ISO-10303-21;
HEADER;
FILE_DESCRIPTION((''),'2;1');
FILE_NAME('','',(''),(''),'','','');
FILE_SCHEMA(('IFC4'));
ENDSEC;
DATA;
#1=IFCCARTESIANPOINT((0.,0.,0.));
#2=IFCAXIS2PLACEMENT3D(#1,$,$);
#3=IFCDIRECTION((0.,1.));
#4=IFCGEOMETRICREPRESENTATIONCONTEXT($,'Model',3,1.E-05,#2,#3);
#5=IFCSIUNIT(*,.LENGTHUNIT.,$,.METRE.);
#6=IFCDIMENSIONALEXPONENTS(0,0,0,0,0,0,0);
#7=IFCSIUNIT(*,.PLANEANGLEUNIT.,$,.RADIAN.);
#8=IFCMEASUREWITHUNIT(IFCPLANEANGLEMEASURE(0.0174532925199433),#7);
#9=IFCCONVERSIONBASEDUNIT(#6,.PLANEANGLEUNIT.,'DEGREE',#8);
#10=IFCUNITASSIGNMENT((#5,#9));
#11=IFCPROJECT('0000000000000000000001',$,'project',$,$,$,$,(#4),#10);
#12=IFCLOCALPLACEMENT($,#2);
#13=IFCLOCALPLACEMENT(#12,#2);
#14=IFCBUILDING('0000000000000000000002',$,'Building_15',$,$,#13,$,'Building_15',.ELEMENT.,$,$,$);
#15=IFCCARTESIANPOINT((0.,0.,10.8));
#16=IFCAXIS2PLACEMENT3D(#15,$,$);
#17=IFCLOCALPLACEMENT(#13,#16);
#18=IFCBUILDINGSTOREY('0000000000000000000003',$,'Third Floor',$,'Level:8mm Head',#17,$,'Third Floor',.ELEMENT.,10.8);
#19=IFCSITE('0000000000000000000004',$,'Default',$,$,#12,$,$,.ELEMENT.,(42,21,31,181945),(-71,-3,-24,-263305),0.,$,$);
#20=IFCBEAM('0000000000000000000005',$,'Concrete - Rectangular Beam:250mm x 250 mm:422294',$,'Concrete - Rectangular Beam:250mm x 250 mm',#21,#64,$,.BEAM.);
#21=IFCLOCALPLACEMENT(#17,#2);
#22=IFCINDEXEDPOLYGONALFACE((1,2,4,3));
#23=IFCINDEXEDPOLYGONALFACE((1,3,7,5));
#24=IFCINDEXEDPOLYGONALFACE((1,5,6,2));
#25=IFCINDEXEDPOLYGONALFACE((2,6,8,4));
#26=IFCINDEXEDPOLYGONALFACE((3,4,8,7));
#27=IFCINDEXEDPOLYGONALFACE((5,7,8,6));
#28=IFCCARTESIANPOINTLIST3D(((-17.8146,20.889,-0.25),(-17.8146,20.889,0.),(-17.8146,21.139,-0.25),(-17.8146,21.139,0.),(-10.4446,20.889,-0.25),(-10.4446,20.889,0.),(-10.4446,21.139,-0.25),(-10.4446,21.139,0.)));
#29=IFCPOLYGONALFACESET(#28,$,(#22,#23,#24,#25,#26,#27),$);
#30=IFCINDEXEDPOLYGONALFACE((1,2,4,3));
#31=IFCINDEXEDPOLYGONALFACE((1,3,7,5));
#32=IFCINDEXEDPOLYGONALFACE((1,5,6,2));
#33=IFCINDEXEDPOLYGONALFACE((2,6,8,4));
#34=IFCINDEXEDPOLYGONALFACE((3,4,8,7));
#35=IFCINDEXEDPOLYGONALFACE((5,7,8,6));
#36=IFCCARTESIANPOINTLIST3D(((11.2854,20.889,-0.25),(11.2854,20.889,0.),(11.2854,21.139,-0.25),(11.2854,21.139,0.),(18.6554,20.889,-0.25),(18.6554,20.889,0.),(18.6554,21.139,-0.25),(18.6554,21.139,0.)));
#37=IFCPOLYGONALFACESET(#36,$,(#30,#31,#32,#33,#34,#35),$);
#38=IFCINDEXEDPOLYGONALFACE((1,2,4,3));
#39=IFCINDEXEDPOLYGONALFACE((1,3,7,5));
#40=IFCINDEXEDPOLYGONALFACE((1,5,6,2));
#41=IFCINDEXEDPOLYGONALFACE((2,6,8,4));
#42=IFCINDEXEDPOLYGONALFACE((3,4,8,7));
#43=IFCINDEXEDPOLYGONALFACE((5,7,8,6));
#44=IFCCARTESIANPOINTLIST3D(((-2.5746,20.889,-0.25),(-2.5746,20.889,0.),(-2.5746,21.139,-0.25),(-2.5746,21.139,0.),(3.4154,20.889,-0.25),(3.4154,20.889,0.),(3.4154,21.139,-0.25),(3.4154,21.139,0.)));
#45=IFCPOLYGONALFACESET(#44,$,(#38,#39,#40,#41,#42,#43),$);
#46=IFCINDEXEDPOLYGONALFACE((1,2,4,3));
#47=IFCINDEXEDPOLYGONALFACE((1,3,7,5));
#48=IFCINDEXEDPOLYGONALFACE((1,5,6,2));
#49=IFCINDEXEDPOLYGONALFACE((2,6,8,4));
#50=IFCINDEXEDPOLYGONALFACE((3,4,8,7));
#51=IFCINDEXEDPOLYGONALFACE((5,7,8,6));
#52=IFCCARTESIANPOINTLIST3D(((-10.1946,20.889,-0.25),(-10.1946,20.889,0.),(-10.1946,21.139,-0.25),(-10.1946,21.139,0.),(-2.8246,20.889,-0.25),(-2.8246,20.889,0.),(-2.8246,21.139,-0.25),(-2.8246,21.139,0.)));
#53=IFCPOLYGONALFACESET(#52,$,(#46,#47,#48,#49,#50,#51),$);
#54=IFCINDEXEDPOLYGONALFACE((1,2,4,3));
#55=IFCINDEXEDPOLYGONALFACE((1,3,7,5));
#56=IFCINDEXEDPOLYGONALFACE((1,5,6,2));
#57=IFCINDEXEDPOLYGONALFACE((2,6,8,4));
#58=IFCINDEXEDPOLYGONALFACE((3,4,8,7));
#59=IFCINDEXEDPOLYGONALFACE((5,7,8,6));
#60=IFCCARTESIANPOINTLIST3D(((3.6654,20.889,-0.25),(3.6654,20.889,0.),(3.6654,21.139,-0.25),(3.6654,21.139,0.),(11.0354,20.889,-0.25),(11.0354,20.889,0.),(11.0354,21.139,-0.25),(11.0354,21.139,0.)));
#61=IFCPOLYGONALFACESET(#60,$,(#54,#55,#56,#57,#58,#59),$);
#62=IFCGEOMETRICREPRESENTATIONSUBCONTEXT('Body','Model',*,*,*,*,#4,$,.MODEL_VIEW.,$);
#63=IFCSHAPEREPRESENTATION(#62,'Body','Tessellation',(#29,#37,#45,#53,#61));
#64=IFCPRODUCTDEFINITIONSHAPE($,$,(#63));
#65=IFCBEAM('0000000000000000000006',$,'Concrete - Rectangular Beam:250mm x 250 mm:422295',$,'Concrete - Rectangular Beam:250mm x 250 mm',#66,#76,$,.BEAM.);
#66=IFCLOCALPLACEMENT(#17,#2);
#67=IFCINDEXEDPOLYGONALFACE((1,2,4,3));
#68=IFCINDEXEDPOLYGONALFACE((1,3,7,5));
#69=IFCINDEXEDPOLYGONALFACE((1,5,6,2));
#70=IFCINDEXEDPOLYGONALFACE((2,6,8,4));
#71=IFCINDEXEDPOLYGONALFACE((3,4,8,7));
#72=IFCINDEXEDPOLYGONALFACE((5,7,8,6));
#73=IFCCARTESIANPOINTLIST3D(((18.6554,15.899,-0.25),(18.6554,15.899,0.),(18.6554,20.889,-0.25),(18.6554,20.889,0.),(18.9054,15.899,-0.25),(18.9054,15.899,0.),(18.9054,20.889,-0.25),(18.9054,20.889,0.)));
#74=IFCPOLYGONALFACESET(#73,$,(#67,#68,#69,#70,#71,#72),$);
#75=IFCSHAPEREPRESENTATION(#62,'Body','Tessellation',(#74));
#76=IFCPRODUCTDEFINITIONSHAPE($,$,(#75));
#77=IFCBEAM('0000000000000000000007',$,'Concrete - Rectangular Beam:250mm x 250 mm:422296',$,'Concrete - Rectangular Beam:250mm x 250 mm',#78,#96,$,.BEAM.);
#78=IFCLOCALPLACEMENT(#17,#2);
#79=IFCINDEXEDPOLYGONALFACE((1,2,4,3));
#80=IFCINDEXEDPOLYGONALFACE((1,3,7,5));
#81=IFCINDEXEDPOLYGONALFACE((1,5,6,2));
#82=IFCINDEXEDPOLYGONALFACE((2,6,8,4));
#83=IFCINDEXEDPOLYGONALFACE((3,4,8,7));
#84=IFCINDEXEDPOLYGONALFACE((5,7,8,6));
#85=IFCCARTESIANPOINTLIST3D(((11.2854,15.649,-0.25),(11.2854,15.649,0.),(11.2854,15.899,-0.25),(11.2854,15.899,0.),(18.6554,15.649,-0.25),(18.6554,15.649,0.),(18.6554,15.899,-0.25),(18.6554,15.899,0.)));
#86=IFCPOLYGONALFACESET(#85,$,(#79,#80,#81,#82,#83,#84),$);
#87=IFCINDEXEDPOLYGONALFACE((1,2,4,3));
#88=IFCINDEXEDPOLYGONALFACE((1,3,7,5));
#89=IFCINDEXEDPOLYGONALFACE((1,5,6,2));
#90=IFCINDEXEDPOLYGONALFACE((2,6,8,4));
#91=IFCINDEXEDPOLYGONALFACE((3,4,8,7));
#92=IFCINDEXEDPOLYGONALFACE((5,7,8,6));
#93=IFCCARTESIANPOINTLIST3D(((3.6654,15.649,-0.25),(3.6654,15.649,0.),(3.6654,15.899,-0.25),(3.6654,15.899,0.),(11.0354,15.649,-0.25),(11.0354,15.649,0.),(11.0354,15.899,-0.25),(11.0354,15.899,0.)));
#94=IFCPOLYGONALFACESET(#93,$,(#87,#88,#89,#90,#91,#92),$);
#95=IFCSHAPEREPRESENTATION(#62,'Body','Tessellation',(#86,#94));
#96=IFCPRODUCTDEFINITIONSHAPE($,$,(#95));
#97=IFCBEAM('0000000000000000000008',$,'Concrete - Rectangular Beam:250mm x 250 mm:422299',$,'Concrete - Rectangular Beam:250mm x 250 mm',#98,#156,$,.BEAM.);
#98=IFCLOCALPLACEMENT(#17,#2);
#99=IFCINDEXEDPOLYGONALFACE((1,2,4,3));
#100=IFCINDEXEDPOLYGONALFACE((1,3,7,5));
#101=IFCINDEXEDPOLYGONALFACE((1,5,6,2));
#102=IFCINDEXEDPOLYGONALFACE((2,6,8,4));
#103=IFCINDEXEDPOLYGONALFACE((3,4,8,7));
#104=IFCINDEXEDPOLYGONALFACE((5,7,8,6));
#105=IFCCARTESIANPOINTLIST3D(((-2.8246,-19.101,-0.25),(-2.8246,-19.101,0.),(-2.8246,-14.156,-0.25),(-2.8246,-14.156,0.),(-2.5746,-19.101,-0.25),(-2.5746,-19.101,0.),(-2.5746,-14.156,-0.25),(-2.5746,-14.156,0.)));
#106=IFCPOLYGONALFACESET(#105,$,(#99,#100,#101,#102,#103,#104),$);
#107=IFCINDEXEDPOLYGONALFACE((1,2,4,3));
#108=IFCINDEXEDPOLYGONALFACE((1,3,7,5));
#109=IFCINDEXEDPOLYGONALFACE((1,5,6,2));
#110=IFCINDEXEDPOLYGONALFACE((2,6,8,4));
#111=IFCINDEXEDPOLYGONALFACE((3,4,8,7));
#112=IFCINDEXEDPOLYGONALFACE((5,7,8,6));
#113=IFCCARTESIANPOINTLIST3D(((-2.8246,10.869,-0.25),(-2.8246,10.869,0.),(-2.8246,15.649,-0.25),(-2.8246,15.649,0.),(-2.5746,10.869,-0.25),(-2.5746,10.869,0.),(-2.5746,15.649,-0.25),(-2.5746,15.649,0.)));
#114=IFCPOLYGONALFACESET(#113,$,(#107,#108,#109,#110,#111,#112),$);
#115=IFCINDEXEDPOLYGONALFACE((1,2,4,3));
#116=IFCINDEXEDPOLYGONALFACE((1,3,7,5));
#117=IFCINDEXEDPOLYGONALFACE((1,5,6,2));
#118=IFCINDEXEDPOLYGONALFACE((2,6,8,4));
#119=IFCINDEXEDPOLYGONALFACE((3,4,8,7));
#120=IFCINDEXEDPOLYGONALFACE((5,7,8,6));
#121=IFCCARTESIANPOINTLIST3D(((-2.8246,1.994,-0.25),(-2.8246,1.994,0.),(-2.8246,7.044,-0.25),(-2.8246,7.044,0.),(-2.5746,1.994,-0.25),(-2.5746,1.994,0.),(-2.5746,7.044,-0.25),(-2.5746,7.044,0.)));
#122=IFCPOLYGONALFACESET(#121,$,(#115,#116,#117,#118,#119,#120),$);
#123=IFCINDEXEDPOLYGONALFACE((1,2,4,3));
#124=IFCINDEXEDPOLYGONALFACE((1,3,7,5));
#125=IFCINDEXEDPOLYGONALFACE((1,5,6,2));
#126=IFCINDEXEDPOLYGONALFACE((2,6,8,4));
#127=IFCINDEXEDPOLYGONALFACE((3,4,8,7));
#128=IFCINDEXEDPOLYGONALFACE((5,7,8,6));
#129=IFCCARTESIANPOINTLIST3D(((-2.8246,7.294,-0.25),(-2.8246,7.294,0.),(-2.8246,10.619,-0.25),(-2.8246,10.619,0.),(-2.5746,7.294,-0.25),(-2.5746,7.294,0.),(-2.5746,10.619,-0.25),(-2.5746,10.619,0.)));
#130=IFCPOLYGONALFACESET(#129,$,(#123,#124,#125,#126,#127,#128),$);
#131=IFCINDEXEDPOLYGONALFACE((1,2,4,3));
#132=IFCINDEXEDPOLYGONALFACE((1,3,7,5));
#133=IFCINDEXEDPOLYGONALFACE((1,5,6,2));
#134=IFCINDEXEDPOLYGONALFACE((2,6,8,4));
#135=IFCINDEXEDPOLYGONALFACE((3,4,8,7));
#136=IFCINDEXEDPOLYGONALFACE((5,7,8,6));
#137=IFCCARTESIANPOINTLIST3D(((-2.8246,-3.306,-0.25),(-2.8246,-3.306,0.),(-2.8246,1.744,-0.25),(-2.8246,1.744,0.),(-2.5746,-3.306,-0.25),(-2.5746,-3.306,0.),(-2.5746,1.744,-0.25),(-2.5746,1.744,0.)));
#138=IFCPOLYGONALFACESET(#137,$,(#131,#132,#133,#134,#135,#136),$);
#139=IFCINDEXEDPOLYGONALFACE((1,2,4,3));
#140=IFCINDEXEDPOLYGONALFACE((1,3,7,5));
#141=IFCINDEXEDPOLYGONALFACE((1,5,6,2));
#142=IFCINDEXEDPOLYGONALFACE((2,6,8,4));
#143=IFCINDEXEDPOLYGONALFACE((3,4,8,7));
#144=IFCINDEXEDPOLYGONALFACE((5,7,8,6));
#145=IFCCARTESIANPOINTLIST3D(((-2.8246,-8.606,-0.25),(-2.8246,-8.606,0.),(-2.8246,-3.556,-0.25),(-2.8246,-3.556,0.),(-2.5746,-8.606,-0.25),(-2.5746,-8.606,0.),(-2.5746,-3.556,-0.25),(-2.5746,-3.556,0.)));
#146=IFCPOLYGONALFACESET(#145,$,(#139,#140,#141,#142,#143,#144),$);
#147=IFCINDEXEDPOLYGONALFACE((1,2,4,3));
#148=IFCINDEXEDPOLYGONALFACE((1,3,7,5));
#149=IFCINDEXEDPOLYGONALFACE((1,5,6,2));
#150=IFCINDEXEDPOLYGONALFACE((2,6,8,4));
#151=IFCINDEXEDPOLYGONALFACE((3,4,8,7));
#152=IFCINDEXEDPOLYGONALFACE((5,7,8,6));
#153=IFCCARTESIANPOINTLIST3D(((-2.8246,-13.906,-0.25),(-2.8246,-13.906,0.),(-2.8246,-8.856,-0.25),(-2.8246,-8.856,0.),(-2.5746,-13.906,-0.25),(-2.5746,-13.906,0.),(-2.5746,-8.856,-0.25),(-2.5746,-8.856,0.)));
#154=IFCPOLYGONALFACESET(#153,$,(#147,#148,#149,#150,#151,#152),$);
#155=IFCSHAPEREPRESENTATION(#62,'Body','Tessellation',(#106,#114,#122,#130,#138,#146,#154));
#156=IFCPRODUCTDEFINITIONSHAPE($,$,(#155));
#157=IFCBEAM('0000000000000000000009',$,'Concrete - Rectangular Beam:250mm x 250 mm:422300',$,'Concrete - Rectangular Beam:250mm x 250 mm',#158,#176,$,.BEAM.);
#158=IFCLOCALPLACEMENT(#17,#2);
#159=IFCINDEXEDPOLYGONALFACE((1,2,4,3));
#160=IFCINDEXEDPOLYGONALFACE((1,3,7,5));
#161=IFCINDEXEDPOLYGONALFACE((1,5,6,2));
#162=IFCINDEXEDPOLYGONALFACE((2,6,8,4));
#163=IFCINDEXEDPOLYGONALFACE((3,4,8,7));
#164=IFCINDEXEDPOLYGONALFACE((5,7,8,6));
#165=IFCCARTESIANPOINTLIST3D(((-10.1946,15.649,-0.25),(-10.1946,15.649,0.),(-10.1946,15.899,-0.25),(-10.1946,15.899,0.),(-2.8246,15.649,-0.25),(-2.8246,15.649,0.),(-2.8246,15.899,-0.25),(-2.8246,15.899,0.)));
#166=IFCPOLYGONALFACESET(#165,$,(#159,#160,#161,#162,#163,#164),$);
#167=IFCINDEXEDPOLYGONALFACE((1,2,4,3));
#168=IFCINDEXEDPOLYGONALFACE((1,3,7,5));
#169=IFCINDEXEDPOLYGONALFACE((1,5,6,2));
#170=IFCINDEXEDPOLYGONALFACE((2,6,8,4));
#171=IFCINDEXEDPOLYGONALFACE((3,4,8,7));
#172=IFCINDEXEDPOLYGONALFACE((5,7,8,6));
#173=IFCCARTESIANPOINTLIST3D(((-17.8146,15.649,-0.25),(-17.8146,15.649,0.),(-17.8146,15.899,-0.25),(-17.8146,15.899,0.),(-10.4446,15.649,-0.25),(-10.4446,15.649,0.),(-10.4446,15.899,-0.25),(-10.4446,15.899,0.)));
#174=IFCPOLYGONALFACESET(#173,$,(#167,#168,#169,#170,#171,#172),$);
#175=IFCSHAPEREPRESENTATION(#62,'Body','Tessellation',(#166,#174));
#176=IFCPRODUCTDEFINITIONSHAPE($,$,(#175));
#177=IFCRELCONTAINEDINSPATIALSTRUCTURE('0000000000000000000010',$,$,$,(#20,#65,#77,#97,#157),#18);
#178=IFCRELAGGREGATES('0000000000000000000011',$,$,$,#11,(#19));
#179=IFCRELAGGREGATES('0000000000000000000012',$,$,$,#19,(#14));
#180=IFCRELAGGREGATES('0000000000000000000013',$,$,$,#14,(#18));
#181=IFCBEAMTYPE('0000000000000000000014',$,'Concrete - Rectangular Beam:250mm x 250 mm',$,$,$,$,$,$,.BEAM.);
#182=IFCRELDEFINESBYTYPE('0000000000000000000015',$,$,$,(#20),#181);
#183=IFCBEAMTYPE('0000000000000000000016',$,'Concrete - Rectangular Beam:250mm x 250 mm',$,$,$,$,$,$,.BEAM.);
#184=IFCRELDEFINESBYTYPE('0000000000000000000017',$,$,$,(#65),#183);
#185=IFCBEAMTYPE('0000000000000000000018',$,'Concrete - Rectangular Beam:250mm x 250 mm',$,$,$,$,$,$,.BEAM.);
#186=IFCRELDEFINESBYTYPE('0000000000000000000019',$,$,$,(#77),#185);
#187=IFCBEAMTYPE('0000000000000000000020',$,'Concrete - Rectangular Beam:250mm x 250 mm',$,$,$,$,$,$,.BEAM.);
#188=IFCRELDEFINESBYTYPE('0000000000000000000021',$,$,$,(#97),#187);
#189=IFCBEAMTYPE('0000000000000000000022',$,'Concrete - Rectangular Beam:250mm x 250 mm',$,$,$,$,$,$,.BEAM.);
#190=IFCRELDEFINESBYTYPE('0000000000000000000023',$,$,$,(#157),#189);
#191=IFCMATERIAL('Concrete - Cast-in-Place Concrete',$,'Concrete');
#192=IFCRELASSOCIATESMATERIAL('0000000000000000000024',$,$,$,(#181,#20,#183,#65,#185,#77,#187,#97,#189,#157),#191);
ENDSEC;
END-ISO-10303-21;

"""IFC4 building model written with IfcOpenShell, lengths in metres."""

from ifc_helpers import new_model, entity, si_unit, converted_unit, direction, frame, origin, place, context, subcontext, project, spatial, indexed_curve, outline, extrude, source, transform, mapped, material, type_object, type_shapes, element, save


model = new_model("IFC4")

# Units and contexts
model_context = context("Model", 3, precision=1e-05, world=origin(), true_north=direction((0.0, 1.0)))
body_context = subcontext(model_context, "Body", "Model", "MODEL_VIEW")
ifc_project = project(units=[si_unit("LENGTHUNIT", "METRE"), converted_unit("PLANEANGLEUNIT", "DEGREE", entity("IfcPlaneAngleMeasure", 0.0174532925199433), si_unit("PLANEANGLEUNIT", "RADIAN"), dimensions=[0, 0, 0, 0, 0, 0, 0])], contexts=[model_context])

# Site, building, storey
site_placement = place(None, origin())
site = spatial("IfcSite", under=ifc_project, at=site_placement, Name="Default", CompositionType="ELEMENT", RefLatitude=(42, 21, 31, 181945), RefLongitude=(-71, -3, -24, -263305), RefElevation=0.0)
building_placement = place(site_placement, origin())
building = spatial("IfcBuilding", under=site, at=building_placement, Name="Building_15", LongName="Building_15", CompositionType="ELEMENT")
storey_placement = place(building_placement, frame((0.0, 0.0, 10.8)))
storey = spatial("IfcBuildingStorey", under=building, at=storey_placement, Name="Third Floor", ObjectType="Level:8mm Head", LongName="Third Floor", CompositionType="ELEMENT", Elevation=10.8)

# Shared definitions
ifc_material_1 = material(Name="Concrete - Cast-in-Place Concrete", Category="Concrete")

# Beams
beam_type_1 = type_object("IfcBeamType", Name="Concrete - Rectangular Beam:250mm x 250 mm", PredefinedType="BEAM", material=ifc_material_1)
shared_shape_1 = source(origin(), body_context, "Body", "SweptSolid", [
    extrude(outline(indexed_curve([(-0.125, -0.125), (0.125, -0.125), (0.125, 0.125), (-0.125, 0.125), (-0.125, -0.125)], self_intersect=False)), frame((-17.8146, 21.014, 10.675), z_axis=(1.0, 0.0, 0.0), x_axis=(0.0, 0.0, -1.0)), (0.0, 0.0, 1.0), 7.37),
    extrude(outline(indexed_curve([(-0.125, -0.125), (0.125, -0.125), (0.125, 0.125), (-0.125, 0.125), (-0.125, -0.125)], self_intersect=False)), frame((11.2854, 21.014, 10.675), z_axis=(1.0, 0.0, 0.0), x_axis=(0.0, 0.0, -1.0)), (0.0, 0.0, 1.0), 7.37),
    extrude(outline(indexed_curve([(-0.125, -0.125), (0.125, -0.125), (0.125, 0.125), (-0.125, 0.125), (-0.125, -0.125)], self_intersect=False)), frame((-2.5746, 21.014, 10.675), z_axis=(1.0, 0.0, 0.0), x_axis=(0.0, 0.0, -1.0)), (0.0, 0.0, 1.0), 5.99),
    extrude(outline(indexed_curve([(-0.125, -0.125), (0.125, -0.125), (0.125, 0.125), (-0.125, 0.125), (-0.125, -0.125)], self_intersect=False)), frame((-10.1946, 21.014, 10.675), z_axis=(1.0, 0.0, 0.0), x_axis=(0.0, 0.0, -1.0)), (0.0, 0.0, 1.0), 7.37),
    extrude(outline(indexed_curve([(-0.125, -0.125), (0.125, -0.125), (0.125, 0.125), (-0.125, 0.125), (-0.125, -0.125)], self_intersect=False)), frame((3.6654, 21.014, 10.675), z_axis=(1.0, 0.0, 0.0), x_axis=(0.0, 0.0, -1.0)), (0.0, 0.0, 1.0), 7.37),
])
type_shapes(beam_type_1, [shared_shape_1])
beam_1_placement = place(storey_placement, frame((0.0, 0.0, -10.8)))
element("IfcBeam", 1, at=beam_1_placement, inside=storey, type_object=beam_type_1, material=ifc_material_1, Name="Concrete - Rectangular Beam:250mm x 250 mm:422294", ObjectType="Concrete - Rectangular Beam:250mm x 250 mm", PredefinedType="BEAM", context=body_context, shape_type="MappedRepresentation", body=[
    mapped(shared_shape_1, transform((0.0, 0.0, 0.0), scale=1.0)),
])
beam_type_2 = type_object("IfcBeamType", Name="Concrete - Rectangular Beam:250mm x 250 mm", PredefinedType="BEAM", material=ifc_material_1)
shared_shape_2 = source(origin(), body_context, "Body", "SweptSolid", [
    extrude(outline(indexed_curve([(-0.125, -0.125), (0.125, -0.125), (0.125, 0.125), (-0.125, 0.125), (-0.125, -0.125)], self_intersect=False)), frame((18.7804, 20.889, 10.675), z_axis=(0.0, -1.0, 0.0), x_axis=(-1.0, 0.0, 0.0)), (0.0, 0.0, 1.0), 4.99),
])
type_shapes(beam_type_2, [shared_shape_2])
beam_2_placement = place(storey_placement, frame((0.0, 0.0, -10.8)))
element("IfcBeam", 2, at=beam_2_placement, inside=storey, type_object=beam_type_2, material=ifc_material_1, Name="Concrete - Rectangular Beam:250mm x 250 mm:422295", ObjectType="Concrete - Rectangular Beam:250mm x 250 mm", PredefinedType="BEAM", context=body_context, shape_type="MappedRepresentation", body=[
    mapped(shared_shape_2, transform((0.0, 0.0, 0.0), scale=1.0)),
])
beam_type_3 = type_object("IfcBeamType", Name="Concrete - Rectangular Beam:250mm x 250 mm", PredefinedType="BEAM", material=ifc_material_1)
shared_shape_3 = source(origin(), body_context, "Body", "SweptSolid", [
    extrude(outline(indexed_curve([(-0.125, -0.125), (0.125, -0.125), (0.125, 0.125), (-0.125, 0.125), (-0.125, -0.125)], self_intersect=False)), frame((18.6554, 15.774, 10.675), z_axis=(-1.0, 0.0, 0.0), x_axis=(0.0, 0.0, -1.0)), (0.0, 0.0, 1.0), 7.37),
    extrude(outline(indexed_curve([(-0.125, -0.125), (0.125, -0.125), (0.125, 0.125), (-0.125, 0.125), (-0.125, -0.125)], self_intersect=False)), frame((11.0354, 15.774, 10.675), z_axis=(-1.0, 0.0, 0.0), x_axis=(0.0, 0.0, -1.0)), (0.0, 0.0, 1.0), 7.37),
])
type_shapes(beam_type_3, [shared_shape_3])
beam_3_placement = place(storey_placement, frame((0.0, 0.0, -10.8)))
element("IfcBeam", 3, at=beam_3_placement, inside=storey, type_object=beam_type_3, material=ifc_material_1, Name="Concrete - Rectangular Beam:250mm x 250 mm:422296", ObjectType="Concrete - Rectangular Beam:250mm x 250 mm", PredefinedType="BEAM", context=body_context, shape_type="MappedRepresentation", body=[
    mapped(shared_shape_3, transform((0.0, 0.0, 0.0), scale=1.0)),
])
beam_type_4 = type_object("IfcBeamType", Name="Concrete - Rectangular Beam:250mm x 250 mm", PredefinedType="BEAM", material=ifc_material_1)
shared_shape_4 = source(origin(), body_context, "Body", "SweptSolid", [
    extrude(outline(indexed_curve([(-0.125, -0.125), (0.125, -0.125), (0.125, 0.125), (-0.125, 0.125), (-0.125, -0.125)], self_intersect=False)), frame((-2.6996, -19.101, 10.675), z_axis=(0.0, 1.0, 0.0), x_axis=(-1.0, 0.0, 0.0)), (0.0, 0.0, 1.0), 4.945),
    extrude(outline(indexed_curve([(-0.125, -0.125), (0.125, -0.125), (0.125, 0.125), (-0.125, 0.125), (-0.125, -0.125)], self_intersect=False)), frame((-2.6996, 10.869, 10.675), z_axis=(0.0, 1.0, 0.0), x_axis=(-1.0, 0.0, 0.0)), (0.0, 0.0, 1.0), 4.78),
    extrude(outline(indexed_curve([(-0.125, -0.125), (0.125, -0.125), (0.125, 0.125), (-0.125, 0.125), (-0.125, -0.125)], self_intersect=False)), frame((-2.6996, 1.994, 10.675), z_axis=(0.0, 1.0, 0.0), x_axis=(-1.0, 0.0, 0.0)), (0.0, 0.0, 1.0), 5.05),
    extrude(outline(indexed_curve([(-0.125, -0.125), (0.125, -0.125), (0.125, 0.125), (-0.125, 0.125), (-0.125, -0.125)], self_intersect=False)), frame((-2.6996, 7.294, 10.675), z_axis=(0.0, 1.0, 0.0), x_axis=(-1.0, 0.0, 0.0)), (0.0, 0.0, 1.0), 3.325),
    extrude(outline(indexed_curve([(-0.125, -0.125), (0.125, -0.125), (0.125, 0.125), (-0.125, 0.125), (-0.125, -0.125)], self_intersect=False)), frame((-2.6996, -3.306, 10.675), z_axis=(0.0, 1.0, 0.0), x_axis=(-1.0, 0.0, 0.0)), (0.0, 0.0, 1.0), 5.05),
    extrude(outline(indexed_curve([(-0.125, -0.125), (0.125, -0.125), (0.125, 0.125), (-0.125, 0.125), (-0.125, -0.125)], self_intersect=False)), frame((-2.6996, -8.606, 10.675), z_axis=(0.0, 1.0, 0.0), x_axis=(-1.0, 0.0, 0.0)), (0.0, 0.0, 1.0), 5.05),
    extrude(outline(indexed_curve([(-0.125, -0.125), (0.125, -0.125), (0.125, 0.125), (-0.125, 0.125), (-0.125, -0.125)], self_intersect=False)), frame((-2.6996, -13.906, 10.675), z_axis=(0.0, 1.0, 0.0), x_axis=(-1.0, 0.0, 0.0)), (0.0, 0.0, 1.0), 5.05),
])
type_shapes(beam_type_4, [shared_shape_4])
beam_4_placement = place(storey_placement, frame((0.0, 0.0, -10.8)))
element("IfcBeam", 4, at=beam_4_placement, inside=storey, type_object=beam_type_4, material=ifc_material_1, Name="Concrete - Rectangular Beam:250mm x 250 mm:422299", ObjectType="Concrete - Rectangular Beam:250mm x 250 mm", PredefinedType="BEAM", context=body_context, shape_type="MappedRepresentation", body=[
    mapped(shared_shape_4, transform((0.0, 0.0, 0.0), scale=1.0)),
])
beam_type_5 = type_object("IfcBeamType", Name="Concrete - Rectangular Beam:250mm x 250 mm", PredefinedType="BEAM", material=ifc_material_1)
shared_shape_5 = source(origin(), body_context, "Body", "SweptSolid", [
    extrude(outline(indexed_curve([(-0.125, -0.125), (0.125, -0.125), (0.125, 0.125), (-0.125, 0.125), (-0.125, -0.125)], self_intersect=False)), frame((-2.8246, 15.774, 10.675), z_axis=(-1.0, 0.0, 0.0), x_axis=(0.0, 0.0, -1.0)), (0.0, 0.0, 1.0), 7.37),
    extrude(outline(indexed_curve([(-0.125, -0.125), (0.125, -0.125), (0.125, 0.125), (-0.125, 0.125), (-0.125, -0.125)], self_intersect=False)), frame((-10.4446, 15.774, 10.675), z_axis=(-1.0, 0.0, 0.0), x_axis=(0.0, 0.0, -1.0)), (0.0, 0.0, 1.0), 7.37),
])
type_shapes(beam_type_5, [shared_shape_5])
beam_5_placement = place(storey_placement, frame((0.0, 0.0, -10.8)))
element("IfcBeam", 5, at=beam_5_placement, inside=storey, type_object=beam_type_5, material=ifc_material_1, Name="Concrete - Rectangular Beam:250mm x 250 mm:422300", ObjectType="Concrete - Rectangular Beam:250mm x 250 mm", PredefinedType="BEAM", context=body_context, shape_type="MappedRepresentation", body=[
    mapped(shared_shape_5, transform((0.0, 0.0, 0.0), scale=1.0)),
])

save(model, "model.ifc")
